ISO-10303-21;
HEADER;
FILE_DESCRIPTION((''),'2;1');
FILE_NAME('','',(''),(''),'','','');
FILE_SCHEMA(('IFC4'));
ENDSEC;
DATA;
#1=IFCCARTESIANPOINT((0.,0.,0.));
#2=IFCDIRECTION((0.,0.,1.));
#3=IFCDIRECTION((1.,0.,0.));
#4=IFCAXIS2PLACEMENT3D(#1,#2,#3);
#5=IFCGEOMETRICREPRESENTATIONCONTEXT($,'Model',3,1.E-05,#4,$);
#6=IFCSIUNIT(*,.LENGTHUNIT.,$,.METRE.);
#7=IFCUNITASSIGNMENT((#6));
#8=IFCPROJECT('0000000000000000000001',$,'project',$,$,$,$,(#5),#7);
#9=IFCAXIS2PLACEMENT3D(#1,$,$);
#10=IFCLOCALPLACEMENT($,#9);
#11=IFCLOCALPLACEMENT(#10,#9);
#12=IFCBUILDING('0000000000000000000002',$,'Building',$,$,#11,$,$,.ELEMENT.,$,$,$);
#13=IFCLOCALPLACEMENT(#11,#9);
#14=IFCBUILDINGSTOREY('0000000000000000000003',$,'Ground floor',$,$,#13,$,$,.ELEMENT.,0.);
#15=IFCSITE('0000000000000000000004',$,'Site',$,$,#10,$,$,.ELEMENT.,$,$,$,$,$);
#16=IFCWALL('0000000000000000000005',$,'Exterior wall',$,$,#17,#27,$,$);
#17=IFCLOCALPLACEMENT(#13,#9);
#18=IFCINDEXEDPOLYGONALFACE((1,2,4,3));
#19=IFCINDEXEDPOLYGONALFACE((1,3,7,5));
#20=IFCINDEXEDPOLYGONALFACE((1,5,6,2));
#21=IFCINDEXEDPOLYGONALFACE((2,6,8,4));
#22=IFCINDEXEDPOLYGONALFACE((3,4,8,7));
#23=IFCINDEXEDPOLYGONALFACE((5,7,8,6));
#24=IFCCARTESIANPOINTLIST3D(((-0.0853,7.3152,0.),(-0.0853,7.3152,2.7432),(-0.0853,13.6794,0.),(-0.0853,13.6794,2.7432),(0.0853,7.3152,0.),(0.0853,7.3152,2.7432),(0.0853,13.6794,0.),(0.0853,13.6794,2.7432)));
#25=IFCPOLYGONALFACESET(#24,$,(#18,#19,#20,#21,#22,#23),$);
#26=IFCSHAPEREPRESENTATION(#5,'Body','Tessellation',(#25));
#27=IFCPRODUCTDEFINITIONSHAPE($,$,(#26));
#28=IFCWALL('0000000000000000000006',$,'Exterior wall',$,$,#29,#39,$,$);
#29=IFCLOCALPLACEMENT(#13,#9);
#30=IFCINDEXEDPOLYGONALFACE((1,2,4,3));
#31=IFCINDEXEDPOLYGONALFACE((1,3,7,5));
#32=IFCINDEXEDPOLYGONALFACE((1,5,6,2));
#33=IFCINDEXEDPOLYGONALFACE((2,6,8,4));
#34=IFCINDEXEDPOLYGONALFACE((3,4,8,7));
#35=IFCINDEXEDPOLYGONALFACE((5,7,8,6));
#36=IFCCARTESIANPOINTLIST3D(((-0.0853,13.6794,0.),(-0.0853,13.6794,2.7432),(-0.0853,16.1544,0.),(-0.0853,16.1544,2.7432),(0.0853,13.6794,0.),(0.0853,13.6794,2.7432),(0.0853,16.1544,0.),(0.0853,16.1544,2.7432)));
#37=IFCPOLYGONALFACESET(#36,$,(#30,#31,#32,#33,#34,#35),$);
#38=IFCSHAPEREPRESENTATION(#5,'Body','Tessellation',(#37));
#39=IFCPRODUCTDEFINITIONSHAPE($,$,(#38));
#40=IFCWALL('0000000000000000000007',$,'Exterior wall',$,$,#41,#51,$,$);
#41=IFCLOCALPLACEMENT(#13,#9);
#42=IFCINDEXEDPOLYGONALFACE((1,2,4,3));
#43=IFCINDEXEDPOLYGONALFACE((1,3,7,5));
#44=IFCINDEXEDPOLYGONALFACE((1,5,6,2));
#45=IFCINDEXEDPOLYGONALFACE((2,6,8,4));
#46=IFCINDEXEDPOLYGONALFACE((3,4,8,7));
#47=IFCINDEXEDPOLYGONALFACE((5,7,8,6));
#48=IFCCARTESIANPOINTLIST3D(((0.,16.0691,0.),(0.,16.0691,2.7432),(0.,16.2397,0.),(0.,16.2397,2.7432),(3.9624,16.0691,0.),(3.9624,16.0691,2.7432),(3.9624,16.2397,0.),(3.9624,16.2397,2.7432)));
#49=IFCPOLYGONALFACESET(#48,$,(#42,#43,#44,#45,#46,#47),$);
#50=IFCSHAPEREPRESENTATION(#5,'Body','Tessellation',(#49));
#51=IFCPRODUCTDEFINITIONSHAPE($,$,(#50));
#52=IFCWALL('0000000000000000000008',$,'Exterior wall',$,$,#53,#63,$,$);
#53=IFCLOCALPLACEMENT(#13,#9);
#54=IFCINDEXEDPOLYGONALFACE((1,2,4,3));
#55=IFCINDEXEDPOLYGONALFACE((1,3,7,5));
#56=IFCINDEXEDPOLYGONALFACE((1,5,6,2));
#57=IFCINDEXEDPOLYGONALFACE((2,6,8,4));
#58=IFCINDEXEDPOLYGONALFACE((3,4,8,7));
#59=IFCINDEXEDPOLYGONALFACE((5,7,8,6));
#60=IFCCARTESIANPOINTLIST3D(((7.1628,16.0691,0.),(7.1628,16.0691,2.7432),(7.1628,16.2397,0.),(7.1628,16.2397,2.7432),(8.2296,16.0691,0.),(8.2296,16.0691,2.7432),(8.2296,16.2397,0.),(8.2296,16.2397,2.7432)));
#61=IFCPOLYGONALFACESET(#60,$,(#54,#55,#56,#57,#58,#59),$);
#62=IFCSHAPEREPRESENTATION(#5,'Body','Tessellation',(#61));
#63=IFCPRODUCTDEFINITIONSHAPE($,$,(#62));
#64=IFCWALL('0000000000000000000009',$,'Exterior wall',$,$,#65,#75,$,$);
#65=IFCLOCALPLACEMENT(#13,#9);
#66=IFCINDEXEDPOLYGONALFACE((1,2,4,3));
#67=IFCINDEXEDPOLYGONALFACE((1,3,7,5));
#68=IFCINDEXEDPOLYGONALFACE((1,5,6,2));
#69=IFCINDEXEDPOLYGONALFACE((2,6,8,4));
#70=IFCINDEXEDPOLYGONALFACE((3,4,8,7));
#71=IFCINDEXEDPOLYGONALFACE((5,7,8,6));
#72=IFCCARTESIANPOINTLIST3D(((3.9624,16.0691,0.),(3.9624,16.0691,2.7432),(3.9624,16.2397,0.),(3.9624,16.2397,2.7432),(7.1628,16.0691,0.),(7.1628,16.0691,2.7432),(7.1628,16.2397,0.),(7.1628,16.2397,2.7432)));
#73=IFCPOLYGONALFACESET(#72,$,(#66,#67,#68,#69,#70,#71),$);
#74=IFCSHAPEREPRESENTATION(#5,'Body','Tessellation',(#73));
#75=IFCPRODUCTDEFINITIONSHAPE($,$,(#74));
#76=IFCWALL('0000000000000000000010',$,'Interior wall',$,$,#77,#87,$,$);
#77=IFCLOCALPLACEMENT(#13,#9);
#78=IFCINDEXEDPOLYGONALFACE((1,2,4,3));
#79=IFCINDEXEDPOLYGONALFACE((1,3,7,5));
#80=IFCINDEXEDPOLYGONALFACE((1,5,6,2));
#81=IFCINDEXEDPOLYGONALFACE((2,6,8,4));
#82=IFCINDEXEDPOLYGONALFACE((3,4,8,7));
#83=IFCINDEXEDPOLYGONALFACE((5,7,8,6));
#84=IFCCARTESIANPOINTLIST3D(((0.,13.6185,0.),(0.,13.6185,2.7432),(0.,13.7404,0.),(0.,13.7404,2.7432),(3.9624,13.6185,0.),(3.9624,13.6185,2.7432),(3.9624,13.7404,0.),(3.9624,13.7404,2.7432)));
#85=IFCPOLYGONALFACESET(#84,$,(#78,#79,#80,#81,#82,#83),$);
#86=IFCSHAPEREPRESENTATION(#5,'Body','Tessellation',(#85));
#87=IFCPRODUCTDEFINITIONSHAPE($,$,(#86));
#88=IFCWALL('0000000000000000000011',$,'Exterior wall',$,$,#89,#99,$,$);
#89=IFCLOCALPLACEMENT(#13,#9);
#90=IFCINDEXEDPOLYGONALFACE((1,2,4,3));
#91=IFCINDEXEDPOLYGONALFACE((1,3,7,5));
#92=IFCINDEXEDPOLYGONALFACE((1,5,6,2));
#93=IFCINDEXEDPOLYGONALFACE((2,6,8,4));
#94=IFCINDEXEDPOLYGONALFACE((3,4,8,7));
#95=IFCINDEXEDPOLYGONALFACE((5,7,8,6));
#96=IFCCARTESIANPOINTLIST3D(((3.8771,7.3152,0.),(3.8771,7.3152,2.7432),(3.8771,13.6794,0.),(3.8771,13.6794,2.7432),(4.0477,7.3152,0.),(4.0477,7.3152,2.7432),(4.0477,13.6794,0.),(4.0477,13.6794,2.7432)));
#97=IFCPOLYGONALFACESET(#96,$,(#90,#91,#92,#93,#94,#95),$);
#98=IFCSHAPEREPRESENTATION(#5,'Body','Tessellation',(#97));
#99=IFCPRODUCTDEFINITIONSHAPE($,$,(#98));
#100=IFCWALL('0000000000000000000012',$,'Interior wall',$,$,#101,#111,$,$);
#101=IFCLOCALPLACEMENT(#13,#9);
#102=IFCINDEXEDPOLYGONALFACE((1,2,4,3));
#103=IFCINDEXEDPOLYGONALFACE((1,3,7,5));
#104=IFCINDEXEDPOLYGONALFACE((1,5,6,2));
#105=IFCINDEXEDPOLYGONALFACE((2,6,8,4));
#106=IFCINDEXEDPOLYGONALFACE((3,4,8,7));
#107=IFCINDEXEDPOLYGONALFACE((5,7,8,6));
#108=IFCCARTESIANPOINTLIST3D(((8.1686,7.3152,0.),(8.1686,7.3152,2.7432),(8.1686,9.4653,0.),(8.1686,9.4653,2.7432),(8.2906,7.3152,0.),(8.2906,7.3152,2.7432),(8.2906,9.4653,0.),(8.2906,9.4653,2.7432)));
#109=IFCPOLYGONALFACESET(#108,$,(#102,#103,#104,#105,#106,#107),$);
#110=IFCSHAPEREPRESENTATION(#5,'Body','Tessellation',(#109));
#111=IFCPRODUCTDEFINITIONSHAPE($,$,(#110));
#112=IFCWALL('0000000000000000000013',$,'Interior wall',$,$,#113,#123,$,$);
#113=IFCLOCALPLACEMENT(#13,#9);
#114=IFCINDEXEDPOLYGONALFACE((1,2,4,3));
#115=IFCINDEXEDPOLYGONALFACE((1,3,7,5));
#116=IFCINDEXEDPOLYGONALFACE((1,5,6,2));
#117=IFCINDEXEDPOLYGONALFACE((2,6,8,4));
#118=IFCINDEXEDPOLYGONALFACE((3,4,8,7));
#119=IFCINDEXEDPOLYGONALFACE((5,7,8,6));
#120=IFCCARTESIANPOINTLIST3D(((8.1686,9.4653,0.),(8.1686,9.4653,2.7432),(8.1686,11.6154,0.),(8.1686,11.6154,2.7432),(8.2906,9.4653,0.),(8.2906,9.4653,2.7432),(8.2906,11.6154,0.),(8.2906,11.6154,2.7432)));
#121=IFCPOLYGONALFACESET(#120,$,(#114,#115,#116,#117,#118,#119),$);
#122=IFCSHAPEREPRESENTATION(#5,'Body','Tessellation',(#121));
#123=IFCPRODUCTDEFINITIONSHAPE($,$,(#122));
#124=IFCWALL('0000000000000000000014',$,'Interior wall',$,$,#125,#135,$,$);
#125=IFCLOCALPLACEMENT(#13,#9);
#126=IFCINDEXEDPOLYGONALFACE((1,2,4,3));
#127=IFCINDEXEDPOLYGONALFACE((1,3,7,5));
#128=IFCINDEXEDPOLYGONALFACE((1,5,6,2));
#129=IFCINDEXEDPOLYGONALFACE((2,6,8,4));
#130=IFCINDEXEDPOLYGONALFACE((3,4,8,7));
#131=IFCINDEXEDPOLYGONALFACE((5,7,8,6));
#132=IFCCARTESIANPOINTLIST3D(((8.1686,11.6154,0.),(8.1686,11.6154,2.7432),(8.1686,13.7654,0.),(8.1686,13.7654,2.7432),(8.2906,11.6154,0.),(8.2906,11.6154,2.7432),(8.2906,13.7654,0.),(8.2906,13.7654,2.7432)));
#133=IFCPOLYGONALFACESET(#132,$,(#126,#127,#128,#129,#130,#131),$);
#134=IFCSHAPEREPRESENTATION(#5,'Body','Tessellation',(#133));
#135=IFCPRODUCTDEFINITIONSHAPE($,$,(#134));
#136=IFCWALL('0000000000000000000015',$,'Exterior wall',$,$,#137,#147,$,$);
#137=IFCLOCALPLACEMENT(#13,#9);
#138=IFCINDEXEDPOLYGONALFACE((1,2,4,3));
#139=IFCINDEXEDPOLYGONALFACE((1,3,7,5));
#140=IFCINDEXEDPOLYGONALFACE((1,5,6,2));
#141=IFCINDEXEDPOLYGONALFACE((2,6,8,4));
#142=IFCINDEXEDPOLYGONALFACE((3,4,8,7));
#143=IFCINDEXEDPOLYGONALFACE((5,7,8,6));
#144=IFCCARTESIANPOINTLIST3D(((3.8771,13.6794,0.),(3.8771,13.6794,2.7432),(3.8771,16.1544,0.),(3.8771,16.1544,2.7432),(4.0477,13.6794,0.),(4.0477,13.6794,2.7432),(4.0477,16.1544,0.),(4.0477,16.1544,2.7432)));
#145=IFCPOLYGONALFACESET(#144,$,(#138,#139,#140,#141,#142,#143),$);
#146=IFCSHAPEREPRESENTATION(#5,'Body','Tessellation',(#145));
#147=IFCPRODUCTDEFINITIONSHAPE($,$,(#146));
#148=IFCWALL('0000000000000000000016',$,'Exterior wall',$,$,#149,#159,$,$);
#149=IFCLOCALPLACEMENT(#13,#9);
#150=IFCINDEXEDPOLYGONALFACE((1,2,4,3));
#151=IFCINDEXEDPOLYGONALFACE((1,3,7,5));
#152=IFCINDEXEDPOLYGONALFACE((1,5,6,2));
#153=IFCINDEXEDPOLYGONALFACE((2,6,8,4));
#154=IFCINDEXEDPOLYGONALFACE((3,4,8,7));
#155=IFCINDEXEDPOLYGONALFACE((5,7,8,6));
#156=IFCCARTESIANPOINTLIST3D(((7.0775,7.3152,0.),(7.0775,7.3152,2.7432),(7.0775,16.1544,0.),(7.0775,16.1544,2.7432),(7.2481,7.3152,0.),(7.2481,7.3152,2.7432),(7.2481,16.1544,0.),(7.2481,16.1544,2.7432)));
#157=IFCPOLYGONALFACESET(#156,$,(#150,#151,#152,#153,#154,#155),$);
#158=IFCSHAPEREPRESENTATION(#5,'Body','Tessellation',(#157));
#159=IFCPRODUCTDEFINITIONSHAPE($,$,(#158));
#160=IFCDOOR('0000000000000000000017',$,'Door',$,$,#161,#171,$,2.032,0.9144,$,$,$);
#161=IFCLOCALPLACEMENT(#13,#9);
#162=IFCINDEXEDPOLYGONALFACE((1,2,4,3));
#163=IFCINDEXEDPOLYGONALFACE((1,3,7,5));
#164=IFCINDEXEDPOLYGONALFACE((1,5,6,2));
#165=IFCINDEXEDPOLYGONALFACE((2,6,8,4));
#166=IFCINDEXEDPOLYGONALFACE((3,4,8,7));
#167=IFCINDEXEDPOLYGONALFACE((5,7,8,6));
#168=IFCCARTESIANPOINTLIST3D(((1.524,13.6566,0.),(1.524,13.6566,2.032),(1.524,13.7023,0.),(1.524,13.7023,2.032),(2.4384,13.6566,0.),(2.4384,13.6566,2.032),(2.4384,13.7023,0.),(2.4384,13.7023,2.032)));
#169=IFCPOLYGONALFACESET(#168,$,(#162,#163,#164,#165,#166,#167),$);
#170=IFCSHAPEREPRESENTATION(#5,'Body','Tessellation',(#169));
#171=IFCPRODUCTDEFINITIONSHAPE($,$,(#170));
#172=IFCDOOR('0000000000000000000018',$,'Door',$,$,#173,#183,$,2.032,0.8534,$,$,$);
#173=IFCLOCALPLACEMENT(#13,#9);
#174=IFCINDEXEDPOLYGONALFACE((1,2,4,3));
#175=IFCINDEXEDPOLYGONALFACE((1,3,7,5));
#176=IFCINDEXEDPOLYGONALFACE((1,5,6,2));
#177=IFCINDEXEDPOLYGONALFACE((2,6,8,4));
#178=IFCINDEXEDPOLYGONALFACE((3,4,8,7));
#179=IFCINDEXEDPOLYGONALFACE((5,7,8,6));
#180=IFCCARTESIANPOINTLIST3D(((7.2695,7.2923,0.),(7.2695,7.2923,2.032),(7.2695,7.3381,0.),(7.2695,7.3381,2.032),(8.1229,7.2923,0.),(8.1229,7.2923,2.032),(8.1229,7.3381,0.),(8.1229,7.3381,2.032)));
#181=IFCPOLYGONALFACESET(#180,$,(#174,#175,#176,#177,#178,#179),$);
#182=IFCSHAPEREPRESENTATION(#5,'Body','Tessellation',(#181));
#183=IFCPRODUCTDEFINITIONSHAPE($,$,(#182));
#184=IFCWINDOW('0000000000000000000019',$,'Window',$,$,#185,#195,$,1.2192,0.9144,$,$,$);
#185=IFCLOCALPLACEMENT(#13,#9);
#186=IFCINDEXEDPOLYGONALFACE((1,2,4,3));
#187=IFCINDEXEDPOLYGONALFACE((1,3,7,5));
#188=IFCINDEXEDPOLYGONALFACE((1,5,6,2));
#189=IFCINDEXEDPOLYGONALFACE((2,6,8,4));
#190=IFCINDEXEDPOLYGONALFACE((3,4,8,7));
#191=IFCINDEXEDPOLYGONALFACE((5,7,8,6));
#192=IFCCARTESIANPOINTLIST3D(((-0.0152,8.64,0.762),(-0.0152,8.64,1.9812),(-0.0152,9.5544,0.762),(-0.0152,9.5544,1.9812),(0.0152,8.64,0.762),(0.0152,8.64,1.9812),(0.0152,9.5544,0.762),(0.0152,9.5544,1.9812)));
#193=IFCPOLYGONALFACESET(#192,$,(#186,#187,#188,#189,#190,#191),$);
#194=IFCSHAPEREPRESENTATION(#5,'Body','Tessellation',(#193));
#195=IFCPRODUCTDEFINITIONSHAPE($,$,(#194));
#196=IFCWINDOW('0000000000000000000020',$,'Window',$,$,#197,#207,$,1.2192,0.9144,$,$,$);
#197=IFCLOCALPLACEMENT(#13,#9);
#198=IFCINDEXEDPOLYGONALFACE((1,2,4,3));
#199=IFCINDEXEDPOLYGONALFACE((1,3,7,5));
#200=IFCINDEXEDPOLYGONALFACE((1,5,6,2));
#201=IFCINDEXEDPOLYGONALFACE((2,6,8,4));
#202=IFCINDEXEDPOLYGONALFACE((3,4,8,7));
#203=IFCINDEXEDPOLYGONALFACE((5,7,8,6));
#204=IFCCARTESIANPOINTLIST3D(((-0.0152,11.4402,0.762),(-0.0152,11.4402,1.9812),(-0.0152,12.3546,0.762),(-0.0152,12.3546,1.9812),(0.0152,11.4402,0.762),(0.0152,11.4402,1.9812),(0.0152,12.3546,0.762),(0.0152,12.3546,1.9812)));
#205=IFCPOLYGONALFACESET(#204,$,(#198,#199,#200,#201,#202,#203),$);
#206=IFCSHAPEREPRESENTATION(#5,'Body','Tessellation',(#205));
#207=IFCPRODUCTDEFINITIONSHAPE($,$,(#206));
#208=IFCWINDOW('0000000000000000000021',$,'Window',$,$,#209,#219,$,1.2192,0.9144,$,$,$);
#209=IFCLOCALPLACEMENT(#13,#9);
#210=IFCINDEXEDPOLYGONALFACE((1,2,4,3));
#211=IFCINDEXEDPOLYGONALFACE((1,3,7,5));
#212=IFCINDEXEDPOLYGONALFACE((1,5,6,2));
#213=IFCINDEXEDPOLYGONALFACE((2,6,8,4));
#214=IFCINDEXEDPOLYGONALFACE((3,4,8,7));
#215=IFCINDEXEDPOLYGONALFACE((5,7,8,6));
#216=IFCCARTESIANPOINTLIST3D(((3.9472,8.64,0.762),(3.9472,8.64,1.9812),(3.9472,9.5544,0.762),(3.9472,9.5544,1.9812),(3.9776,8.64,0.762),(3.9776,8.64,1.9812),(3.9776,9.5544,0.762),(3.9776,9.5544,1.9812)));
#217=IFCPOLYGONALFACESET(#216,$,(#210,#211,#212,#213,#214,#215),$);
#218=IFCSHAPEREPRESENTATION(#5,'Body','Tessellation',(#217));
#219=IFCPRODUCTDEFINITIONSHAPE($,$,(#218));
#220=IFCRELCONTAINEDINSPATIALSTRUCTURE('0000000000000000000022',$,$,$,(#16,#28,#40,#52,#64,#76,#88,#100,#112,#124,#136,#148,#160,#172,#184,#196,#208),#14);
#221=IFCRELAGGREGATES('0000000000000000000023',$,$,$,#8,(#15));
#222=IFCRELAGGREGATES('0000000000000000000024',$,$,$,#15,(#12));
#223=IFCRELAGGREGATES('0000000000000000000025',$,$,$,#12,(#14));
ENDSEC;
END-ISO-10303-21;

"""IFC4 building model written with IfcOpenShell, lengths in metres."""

from ifc_helpers import new_model, si_unit, frame, origin, origin_with_axes, origin_2d, place, context, project, spatial, rectangle, extrude, element, save


model = new_model("IFC4")

# Units and contexts
model_context = context("Model", 3, precision=1e-05, world=origin_with_axes())
ifc_project = project(units=[si_unit("LENGTHUNIT", "METRE")], contexts=[model_context])

# Site, building, storey
site_placement = place(None, origin())
site = spatial("IfcSite", under=ifc_project, at=site_placement, Name="Site", CompositionType="ELEMENT")
building_placement = place(site_placement, origin())
building = spatial("IfcBuilding", under=site, at=building_placement, Name="Building", CompositionType="ELEMENT")
storey_placement = place(building_placement, origin())
storey = spatial("IfcBuildingStorey", under=building, at=storey_placement, Name="Ground floor", CompositionType="ELEMENT", Elevation=0.0)

# Walls
wall_1_placement = place(storey_placement, frame((0.0, 10.4973, 0.0), x_axis=(0.0, 1.0, 0.0)))
element("IfcWall", 1, at=wall_1_placement, inside=storey, Name="Exterior wall", context=model_context, shape_type="SweptSolid", body=[
    extrude(rectangle(XDim=6.3642, YDim=0.1707, at=origin_2d()), origin(), (0.0, 0.0, 1.0), 2.7432),
])
wall_2_placement = place(storey_placement, frame((0.0, 14.9169, 0.0), x_axis=(0.0, 1.0, 0.0)))
element("IfcWall", 2, at=wall_2_placement, inside=storey, Name="Exterior wall", context=model_context, shape_type="SweptSolid", body=[
    extrude(rectangle(XDim=2.475, YDim=0.1707, at=origin_2d()), origin(), (0.0, 0.0, 1.0), 2.7432),
])
wall_3_placement = place(storey_placement, frame((1.9812, 16.1544, 0.0), x_axis=(1.0, 0.0, 0.0)))
element("IfcWall", 3, at=wall_3_placement, inside=storey, Name="Exterior wall", context=model_context, shape_type="SweptSolid", body=[
    extrude(rectangle(XDim=3.9624, YDim=0.1707, at=origin_2d()), origin(), (0.0, 0.0, 1.0), 2.7432),
])
wall_4_placement = place(storey_placement, frame((7.6962, 16.1544, 0.0), x_axis=(1.0, 0.0, 0.0)))
element("IfcWall", 4, at=wall_4_placement, inside=storey, Name="Exterior wall", context=model_context, shape_type="SweptSolid", body=[
    extrude(rectangle(XDim=1.0668, YDim=0.1707, at=origin_2d()), origin(), (0.0, 0.0, 1.0), 2.7432),
])
wall_5_placement = place(storey_placement, frame((5.5626, 16.1544, 0.0), x_axis=(1.0, 0.0, 0.0)))
element("IfcWall", 5, at=wall_5_placement, inside=storey, Name="Exterior wall", context=model_context, shape_type="SweptSolid", body=[
    extrude(rectangle(XDim=3.2004, YDim=0.1707, at=origin_2d()), origin(), (0.0, 0.0, 1.0), 2.7432),
])
wall_6_placement = place(storey_placement, frame((1.9812, 13.6794, 0.0), x_axis=(1.0, 0.0, 0.0)))
element("IfcWall", 6, at=wall_6_placement, inside=storey, Name="Interior wall", context=model_context, shape_type="SweptSolid", body=[
    extrude(rectangle(XDim=3.9624, YDim=0.1219, at=origin_2d()), origin(), (0.0, 0.0, 1.0), 2.7432),
])
wall_7_placement = place(storey_placement, frame((3.9624, 10.4973, 0.0), x_axis=(0.0, 1.0, 0.0)))
element("IfcWall", 7, at=wall_7_placement, inside=storey, Name="Exterior wall", context=model_context, shape_type="SweptSolid", body=[
    extrude(rectangle(XDim=6.3642, YDim=0.1707, at=origin_2d()), origin(), (0.0, 0.0, 1.0), 2.7432),
])
wall_8_placement = place(storey_placement, frame((8.2296, 8.3902, 0.0), x_axis=(0.0, 1.0, 0.0)))
element("IfcWall", 8, at=wall_8_placement, inside=storey, Name="Interior wall", context=model_context, shape_type="SweptSolid", body=[
    extrude(rectangle(XDim=2.1501, YDim=0.1219, at=origin_2d()), origin(), (0.0, 0.0, 1.0), 2.7432),
])
wall_9_placement = place(storey_placement, frame((8.2296, 10.5403, 0.0), x_axis=(0.0, 1.0, 0.0)))
element("IfcWall", 9, at=wall_9_placement, inside=storey, Name="Interior wall", context=model_context, shape_type="SweptSolid", body=[
    extrude(rectangle(XDim=2.1501, YDim=0.1219, at=origin_2d()), origin(), (0.0, 0.0, 1.0), 2.7432),
])
wall_10_placement = place(storey_placement, frame((8.2296, 12.6904, 0.0), x_axis=(0.0, 1.0, 0.0)))
element("IfcWall", 10, at=wall_10_placement, inside=storey, Name="Interior wall", context=model_context, shape_type="SweptSolid", body=[
    extrude(rectangle(XDim=2.1501, YDim=0.1219, at=origin_2d()), origin(), (0.0, 0.0, 1.0), 2.7432),
])
wall_11_placement = place(storey_placement, frame((3.9624, 14.9169, 0.0), x_axis=(0.0, 1.0, 0.0)))
element("IfcWall", 11, at=wall_11_placement, inside=storey, Name="Exterior wall", context=model_context, shape_type="SweptSolid", body=[
    extrude(rectangle(XDim=2.475, YDim=0.1707, at=origin_2d()), origin(), (0.0, 0.0, 1.0), 2.7432),
])
wall_12_placement = place(storey_placement, frame((7.1628, 11.7348, 0.0), x_axis=(0.0, 1.0, 0.0)))
element("IfcWall", 12, at=wall_12_placement, inside=storey, Name="Exterior wall", context=model_context, shape_type="SweptSolid", body=[
    extrude(rectangle(XDim=8.8392, YDim=0.1707, at=origin_2d()), origin(), (0.0, 0.0, 1.0), 2.7432),
])

# Doors
door_1_placement = place(storey_placement, frame((1.9812, 13.6794, 0.0), x_axis=(1.0, 0.0, 0.0)))
element("IfcDoor", 13, at=door_1_placement, inside=storey, Name="Door", OverallHeight=2.032, OverallWidth=0.9144, context=model_context, shape_type="SweptSolid", body=[
    extrude(rectangle(XDim=0.9144, YDim=0.0457, at=origin_2d()), origin(), (0.0, 0.0, 1.0), 2.032),
])
door_2_placement = place(storey_placement, frame((7.6962, 7.3152, 0.0), x_axis=(1.0, 0.0, 0.0)))
element("IfcDoor", 14, at=door_2_placement, inside=storey, Name="Door", OverallHeight=2.032, OverallWidth=0.8534, context=model_context, shape_type="SweptSolid", body=[
    extrude(rectangle(XDim=0.8534, YDim=0.0457, at=origin_2d()), origin(), (0.0, 0.0, 1.0), 2.032),
])

# Windows
for number, where, x_axis, name in (
    (15, (0.0, 9.0972, 0.762), (0.0, 1.0, 0.0), "Window"),
    (16, (0.0, 11.8974, 0.762), (0.0, 1.0, 0.0), "Window"),
    (17, (3.9624, 9.0972, 0.762), (0.0, 1.0, 0.0), "Window"),
):
    element("IfcWindow", number, at=place(storey_placement, frame(where, x_axis=x_axis)), inside=storey, Name=name, OverallHeight=1.2192, OverallWidth=0.9144, context=model_context, shape_type="SweptSolid", body=[
        extrude(rectangle(XDim=0.9144, YDim=0.0305, at=origin_2d()), origin(), (0.0, 0.0, 1.0), 1.2192),
    ])

save(model, "model.ifc")
